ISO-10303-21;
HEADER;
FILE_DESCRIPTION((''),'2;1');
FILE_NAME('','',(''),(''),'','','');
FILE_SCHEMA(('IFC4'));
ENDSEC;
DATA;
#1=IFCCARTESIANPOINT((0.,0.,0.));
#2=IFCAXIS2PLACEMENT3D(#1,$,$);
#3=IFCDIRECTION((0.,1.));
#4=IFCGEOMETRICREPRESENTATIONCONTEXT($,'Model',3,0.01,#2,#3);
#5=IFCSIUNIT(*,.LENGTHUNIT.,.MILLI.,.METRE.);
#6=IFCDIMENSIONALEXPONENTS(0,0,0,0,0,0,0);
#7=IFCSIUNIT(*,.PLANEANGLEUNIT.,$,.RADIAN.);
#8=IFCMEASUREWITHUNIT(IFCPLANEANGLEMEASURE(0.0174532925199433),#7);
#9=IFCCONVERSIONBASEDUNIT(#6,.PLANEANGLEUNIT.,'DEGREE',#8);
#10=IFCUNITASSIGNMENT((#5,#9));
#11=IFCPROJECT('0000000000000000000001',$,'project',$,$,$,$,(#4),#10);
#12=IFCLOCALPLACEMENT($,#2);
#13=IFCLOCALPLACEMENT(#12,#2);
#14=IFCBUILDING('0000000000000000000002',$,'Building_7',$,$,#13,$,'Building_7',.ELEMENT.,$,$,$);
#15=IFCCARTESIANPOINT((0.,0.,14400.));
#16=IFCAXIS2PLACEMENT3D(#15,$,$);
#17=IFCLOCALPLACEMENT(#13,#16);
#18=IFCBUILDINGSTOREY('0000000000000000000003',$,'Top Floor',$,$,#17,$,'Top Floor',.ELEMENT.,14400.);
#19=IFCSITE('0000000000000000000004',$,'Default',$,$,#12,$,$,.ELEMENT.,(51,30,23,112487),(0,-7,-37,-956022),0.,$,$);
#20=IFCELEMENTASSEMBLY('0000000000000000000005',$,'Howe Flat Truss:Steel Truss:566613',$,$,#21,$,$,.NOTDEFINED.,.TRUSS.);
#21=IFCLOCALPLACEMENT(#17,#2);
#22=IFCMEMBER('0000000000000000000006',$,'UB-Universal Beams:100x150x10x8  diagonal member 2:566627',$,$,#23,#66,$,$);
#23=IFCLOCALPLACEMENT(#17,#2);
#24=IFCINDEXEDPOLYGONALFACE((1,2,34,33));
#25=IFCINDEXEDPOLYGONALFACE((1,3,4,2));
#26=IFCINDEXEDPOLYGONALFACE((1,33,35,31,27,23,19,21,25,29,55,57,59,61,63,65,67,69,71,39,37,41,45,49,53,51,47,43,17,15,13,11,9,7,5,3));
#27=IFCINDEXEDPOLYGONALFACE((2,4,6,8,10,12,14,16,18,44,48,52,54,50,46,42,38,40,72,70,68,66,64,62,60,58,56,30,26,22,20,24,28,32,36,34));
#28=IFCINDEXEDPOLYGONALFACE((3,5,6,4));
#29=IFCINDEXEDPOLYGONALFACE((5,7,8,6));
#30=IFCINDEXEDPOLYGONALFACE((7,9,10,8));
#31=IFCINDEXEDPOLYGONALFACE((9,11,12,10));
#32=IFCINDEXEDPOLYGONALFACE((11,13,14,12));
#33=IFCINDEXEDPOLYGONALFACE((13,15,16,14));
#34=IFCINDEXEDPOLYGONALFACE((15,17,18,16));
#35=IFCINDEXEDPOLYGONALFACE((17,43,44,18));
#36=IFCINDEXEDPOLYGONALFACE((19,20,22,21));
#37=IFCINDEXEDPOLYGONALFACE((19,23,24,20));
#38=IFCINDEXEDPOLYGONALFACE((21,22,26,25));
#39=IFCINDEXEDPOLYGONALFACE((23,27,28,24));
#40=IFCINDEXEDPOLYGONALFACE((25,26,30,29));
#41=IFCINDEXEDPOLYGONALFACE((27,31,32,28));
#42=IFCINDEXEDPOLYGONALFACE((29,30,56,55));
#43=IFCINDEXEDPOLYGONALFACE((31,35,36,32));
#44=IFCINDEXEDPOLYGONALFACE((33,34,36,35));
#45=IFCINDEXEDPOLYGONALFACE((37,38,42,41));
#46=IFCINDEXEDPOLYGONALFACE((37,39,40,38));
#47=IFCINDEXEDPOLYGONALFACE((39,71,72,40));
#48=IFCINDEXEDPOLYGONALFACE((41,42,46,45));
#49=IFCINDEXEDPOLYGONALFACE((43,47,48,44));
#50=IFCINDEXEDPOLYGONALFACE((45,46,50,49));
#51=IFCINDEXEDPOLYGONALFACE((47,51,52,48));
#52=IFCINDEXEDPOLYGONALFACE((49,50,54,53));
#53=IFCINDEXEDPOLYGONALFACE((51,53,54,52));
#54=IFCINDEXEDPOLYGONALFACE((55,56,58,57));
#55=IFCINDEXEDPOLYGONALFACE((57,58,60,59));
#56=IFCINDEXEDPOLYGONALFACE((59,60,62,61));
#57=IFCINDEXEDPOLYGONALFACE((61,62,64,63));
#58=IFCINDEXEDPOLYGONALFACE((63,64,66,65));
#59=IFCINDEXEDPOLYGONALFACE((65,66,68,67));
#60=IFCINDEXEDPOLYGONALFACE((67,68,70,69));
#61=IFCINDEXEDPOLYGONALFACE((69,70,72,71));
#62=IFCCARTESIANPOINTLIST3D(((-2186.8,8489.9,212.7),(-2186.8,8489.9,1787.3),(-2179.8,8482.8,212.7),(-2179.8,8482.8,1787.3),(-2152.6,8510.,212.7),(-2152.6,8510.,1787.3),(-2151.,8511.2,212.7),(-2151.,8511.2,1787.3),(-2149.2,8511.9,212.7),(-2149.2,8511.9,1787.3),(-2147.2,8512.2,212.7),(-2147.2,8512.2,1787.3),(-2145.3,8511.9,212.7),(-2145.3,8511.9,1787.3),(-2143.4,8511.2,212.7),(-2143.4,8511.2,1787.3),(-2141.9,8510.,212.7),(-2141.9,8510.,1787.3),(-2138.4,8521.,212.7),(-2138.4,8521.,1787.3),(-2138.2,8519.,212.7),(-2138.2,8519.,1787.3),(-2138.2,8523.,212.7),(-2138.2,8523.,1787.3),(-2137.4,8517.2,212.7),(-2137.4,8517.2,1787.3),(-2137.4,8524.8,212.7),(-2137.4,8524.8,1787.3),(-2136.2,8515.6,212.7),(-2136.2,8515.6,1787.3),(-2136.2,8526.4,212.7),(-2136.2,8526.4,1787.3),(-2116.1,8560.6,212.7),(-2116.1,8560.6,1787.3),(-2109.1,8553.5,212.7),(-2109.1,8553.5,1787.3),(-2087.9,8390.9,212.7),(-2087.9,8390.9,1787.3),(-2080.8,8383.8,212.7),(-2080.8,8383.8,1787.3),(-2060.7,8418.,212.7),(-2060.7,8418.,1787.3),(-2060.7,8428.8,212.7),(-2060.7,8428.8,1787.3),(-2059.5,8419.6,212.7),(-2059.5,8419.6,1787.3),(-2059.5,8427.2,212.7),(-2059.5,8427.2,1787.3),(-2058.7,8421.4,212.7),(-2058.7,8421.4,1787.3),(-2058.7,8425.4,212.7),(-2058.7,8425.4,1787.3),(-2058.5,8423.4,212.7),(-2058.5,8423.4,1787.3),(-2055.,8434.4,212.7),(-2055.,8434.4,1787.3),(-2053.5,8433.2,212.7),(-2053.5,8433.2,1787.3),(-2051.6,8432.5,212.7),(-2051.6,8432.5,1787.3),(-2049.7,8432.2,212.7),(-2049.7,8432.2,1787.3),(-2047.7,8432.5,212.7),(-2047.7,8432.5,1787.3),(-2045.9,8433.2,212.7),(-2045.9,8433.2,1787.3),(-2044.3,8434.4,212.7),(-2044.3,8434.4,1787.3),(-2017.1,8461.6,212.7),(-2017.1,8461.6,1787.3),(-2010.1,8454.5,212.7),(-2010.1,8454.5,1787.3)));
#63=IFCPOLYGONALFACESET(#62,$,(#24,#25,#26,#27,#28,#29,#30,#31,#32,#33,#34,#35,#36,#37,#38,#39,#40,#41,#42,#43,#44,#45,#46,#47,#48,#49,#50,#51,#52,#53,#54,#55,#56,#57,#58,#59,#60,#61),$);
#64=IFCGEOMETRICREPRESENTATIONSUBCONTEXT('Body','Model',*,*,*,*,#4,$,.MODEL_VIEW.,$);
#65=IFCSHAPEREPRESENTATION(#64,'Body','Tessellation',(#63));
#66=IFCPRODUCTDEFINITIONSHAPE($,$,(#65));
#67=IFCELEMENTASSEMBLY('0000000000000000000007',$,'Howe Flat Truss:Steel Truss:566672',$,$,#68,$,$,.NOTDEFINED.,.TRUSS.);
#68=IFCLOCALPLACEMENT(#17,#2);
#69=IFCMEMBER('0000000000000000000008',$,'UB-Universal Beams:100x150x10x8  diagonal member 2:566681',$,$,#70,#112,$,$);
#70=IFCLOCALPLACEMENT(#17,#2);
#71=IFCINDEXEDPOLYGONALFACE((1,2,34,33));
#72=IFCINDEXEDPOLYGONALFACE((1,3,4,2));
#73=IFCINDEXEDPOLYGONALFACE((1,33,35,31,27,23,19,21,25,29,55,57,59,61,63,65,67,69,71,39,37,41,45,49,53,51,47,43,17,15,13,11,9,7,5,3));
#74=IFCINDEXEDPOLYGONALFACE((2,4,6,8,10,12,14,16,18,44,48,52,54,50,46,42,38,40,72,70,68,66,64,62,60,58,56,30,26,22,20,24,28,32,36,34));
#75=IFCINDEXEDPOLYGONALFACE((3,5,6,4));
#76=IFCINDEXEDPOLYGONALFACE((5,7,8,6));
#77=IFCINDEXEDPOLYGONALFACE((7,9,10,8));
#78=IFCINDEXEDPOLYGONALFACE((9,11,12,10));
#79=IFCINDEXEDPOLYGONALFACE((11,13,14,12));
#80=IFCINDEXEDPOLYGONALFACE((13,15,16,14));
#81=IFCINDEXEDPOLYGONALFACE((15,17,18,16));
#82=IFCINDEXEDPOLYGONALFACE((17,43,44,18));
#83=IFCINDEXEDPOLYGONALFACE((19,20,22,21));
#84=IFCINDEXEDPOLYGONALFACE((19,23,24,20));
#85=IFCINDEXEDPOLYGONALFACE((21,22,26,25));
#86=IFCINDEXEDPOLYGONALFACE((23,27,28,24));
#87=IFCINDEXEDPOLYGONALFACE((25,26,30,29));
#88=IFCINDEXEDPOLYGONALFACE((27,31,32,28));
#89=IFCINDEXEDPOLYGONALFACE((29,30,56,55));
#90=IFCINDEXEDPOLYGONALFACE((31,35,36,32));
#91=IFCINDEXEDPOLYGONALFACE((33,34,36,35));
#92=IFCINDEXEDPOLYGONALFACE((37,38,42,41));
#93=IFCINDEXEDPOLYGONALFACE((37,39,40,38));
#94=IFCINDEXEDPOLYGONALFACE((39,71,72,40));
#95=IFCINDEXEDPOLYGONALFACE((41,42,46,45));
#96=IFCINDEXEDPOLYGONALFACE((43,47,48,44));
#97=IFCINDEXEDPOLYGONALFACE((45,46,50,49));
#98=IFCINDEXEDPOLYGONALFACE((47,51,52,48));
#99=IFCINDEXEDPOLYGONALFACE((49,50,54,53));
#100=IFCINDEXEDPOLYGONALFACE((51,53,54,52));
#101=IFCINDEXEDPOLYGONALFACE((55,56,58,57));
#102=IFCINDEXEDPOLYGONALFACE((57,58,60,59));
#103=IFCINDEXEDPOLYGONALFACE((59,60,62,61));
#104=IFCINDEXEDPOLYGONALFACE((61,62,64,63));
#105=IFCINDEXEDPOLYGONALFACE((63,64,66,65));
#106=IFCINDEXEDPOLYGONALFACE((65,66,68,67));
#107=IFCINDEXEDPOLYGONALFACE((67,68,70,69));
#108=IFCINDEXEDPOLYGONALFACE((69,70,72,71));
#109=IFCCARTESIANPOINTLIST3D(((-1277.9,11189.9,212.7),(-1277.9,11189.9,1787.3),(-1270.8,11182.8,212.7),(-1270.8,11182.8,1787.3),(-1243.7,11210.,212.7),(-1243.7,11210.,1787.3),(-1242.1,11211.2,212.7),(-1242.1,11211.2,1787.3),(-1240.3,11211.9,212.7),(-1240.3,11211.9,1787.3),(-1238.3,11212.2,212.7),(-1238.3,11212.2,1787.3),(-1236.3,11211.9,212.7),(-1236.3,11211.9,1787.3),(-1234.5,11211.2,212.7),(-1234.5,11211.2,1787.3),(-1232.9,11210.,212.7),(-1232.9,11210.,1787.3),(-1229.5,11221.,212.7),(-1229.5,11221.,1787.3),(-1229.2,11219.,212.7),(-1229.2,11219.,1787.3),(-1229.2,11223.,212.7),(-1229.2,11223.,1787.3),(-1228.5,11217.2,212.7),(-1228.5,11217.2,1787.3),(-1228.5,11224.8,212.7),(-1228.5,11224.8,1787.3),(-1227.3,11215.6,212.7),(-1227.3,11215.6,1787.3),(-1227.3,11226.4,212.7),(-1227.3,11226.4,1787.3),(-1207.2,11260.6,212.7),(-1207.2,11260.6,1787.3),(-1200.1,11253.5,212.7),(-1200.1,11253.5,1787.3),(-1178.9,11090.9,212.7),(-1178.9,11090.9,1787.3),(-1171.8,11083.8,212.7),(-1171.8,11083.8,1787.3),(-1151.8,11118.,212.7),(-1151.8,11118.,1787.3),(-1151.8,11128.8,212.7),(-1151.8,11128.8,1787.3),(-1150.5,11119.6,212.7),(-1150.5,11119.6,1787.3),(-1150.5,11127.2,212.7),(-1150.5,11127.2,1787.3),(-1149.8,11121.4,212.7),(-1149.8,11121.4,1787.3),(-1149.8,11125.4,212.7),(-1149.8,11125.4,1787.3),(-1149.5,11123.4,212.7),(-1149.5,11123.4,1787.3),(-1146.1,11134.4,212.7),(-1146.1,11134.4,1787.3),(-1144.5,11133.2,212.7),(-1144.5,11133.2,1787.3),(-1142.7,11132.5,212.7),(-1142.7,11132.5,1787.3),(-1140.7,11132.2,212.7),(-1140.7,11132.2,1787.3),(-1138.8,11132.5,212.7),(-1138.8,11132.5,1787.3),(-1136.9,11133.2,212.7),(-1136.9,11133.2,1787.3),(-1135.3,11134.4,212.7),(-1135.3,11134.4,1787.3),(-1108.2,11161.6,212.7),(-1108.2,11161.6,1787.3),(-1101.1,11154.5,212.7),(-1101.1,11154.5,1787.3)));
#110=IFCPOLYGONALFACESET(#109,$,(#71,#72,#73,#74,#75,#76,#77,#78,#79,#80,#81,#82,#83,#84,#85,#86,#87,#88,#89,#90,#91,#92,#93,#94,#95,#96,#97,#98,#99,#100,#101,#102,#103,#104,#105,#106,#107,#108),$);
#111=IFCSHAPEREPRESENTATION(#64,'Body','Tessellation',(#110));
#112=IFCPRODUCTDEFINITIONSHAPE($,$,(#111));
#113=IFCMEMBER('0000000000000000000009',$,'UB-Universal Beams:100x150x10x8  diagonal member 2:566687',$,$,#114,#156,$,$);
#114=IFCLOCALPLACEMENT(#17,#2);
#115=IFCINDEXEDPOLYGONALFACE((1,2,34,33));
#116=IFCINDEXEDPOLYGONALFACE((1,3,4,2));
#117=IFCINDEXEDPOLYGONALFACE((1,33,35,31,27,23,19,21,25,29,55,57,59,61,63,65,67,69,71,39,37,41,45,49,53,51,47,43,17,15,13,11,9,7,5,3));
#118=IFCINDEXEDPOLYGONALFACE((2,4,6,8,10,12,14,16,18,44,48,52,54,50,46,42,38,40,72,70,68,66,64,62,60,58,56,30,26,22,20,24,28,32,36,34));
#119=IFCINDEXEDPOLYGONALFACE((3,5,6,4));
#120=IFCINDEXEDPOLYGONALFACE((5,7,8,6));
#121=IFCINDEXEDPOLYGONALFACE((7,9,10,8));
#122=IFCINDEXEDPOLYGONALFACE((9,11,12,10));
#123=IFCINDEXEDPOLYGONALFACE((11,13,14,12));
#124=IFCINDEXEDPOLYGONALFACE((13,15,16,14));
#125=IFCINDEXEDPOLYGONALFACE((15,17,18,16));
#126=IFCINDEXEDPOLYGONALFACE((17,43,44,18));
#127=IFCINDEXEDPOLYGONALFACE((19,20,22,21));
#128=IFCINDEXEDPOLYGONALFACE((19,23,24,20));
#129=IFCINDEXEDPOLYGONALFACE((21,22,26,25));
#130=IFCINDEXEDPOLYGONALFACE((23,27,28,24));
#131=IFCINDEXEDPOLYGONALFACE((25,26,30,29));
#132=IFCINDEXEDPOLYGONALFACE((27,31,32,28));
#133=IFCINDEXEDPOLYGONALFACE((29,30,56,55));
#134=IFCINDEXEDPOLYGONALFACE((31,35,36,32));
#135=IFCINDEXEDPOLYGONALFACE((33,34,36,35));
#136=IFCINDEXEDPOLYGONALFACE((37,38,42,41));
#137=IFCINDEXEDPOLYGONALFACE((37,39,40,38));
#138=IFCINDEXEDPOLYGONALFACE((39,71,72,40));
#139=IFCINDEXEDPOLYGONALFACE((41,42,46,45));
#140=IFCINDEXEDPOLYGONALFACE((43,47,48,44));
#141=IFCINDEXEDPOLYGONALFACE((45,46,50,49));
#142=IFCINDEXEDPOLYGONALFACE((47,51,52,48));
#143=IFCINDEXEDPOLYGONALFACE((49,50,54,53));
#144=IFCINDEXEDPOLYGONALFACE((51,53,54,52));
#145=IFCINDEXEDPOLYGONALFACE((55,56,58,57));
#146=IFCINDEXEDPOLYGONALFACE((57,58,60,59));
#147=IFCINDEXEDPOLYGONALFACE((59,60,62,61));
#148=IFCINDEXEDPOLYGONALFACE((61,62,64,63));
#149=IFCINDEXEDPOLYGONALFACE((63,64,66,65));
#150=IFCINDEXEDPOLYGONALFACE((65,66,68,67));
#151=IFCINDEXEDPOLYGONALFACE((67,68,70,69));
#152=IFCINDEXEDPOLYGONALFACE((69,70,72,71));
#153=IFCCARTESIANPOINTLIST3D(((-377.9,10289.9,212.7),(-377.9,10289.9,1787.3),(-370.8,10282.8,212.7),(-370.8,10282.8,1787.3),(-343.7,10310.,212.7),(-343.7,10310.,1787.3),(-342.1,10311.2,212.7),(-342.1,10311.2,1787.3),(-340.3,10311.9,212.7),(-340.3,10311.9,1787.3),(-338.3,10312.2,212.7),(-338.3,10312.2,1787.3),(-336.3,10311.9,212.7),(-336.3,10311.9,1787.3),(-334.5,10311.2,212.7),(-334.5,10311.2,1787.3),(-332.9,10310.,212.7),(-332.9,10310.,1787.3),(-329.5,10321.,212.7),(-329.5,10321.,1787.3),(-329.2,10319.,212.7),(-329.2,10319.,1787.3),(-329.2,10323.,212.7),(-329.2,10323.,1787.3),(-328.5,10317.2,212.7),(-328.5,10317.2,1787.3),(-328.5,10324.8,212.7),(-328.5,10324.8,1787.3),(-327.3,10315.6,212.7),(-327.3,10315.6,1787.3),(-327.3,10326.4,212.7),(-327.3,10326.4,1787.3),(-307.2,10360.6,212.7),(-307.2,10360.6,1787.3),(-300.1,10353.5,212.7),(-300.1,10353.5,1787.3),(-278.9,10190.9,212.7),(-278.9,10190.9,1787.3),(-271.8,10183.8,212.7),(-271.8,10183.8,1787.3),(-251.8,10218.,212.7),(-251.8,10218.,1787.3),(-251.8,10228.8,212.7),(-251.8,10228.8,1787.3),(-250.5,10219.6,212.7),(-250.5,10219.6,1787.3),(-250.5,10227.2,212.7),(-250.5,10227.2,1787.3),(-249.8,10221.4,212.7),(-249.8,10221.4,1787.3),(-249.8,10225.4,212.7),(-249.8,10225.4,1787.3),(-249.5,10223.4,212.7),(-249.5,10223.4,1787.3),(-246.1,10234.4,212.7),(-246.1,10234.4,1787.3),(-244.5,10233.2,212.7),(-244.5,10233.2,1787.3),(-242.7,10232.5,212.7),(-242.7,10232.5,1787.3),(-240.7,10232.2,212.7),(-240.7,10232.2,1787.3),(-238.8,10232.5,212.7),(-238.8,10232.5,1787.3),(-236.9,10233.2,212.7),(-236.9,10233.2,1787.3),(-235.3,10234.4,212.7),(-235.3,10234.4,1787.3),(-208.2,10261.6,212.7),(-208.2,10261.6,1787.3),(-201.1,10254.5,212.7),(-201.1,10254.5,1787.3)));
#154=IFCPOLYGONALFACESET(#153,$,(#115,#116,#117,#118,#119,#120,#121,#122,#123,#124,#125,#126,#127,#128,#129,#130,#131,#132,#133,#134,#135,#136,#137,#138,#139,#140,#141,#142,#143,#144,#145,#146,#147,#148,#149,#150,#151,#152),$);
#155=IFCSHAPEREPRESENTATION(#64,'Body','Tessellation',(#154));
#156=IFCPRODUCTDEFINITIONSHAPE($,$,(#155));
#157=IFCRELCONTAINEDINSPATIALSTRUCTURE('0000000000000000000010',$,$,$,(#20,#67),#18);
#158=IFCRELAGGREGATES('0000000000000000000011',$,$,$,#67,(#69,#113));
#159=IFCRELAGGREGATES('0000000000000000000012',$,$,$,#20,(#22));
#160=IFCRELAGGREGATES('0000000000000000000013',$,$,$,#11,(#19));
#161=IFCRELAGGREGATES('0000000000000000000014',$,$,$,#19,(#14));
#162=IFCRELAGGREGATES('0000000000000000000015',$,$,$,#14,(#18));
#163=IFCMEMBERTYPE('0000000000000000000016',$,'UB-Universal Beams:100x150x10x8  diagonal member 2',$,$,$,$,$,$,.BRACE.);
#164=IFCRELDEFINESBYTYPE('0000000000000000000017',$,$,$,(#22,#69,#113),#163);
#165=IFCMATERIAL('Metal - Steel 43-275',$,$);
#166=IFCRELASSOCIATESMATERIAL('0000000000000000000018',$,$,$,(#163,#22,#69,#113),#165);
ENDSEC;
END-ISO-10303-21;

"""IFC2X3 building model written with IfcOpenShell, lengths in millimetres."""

from ifc_helpers import new_model, entity, si_unit, converted_unit, direction, frame, frame_2d, origin, place, context, subcontext, project, spatial, polyline, circle_curve, parameter, trimmed, segment, composite_curve, outline, extrude, source, transform, mapped, material, type_object, type_shapes, element, aggregate, save


model = new_model("IFC2X3")

# Units and contexts
model_context = context("Model", 3, precision=0.01, world=origin(), true_north=direction((0.0, 1.0)))
body_context = subcontext(model_context, "Body", "Model", "MODEL_VIEW")
ifc_project = project(units=[si_unit("LENGTHUNIT", "METRE", prefix="MILLI"), converted_unit("PLANEANGLEUNIT", "DEGREE", entity("IfcPlaneAngleMeasure", 0.0174532925199433), si_unit("PLANEANGLEUNIT", "RADIAN"), dimensions=[0, 0, 0, 0, 0, 0, 0])], contexts=[model_context])

# Site, building, storey
site_placement = place(None, origin())
site = spatial("IfcSite", under=ifc_project, at=site_placement, Name="Default", CompositionType="ELEMENT", RefLatitude=(51, 30, 23, 112487), RefLongitude=(0, -7, -37, -956022), RefElevation=0.0)
building_placement = place(site_placement, origin())
building = spatial("IfcBuilding", under=site, at=building_placement, Name="Building_7", LongName="Building_7", CompositionType="ELEMENT")
storey_placement = place(building_placement, frame((0.0, 0.0, 14400.0)))
storey = spatial("IfcBuildingStorey", under=building, at=storey_placement, Name="Top Floor", LongName="Top Floor", CompositionType="ELEMENT", Elevation=14400.0)

# Shared definitions
ifc_material = material(Name="Metal - Steel 43-275")

# Shared definitions
member_type_1 = type_object("IfcMemberType", Name="UB-Universal Beams:100x150x10x8  diagonal member 2", PredefinedType="BRACE", material=ifc_material)
shared_shape_1 = source(origin(), body_context, "Body", "SweptSolid", [
    extrude(outline(composite_curve([segment(polyline([(-50.0, -65.0), (-50.0, -75.0)]), True, "CONTINUOUS"), segment(polyline([(-50.0, -75.0), (50.0, -75.0)]), True, "CONTINUOUS"), segment(polyline([(50.0, -75.0), (50.0, -65.0)]), True, "CONTINUOUS"), segment(polyline([(50.0, -65.0), (11.6, -65.0)]), True, "CONTINUOUS"), segment(trimmed(circle_curve(frame_2d((11.6, -57.4), x_axis=(1.0, 0.0)), 7.6), [parameter(180.0)], [parameter(270.0)], True, "PARAMETER"), False, "CONTINUOUS"), segment(polyline([(4.0, -57.4), (4.0, 57.4)]), True, "CONTINUOUS"), segment(trimmed(circle_curve(frame_2d((11.6, 57.4), x_axis=(1.0, 0.0)), 7.6), [parameter(90.0)], [parameter(180.0)], True, "PARAMETER"), False, "CONTINUOUS"), segment(polyline([(11.6, 65.0), (50.0, 65.0)]), True, "CONTINUOUS"), segment(polyline([(50.0, 65.0), (50.0, 75.0)]), True, "CONTINUOUS"), segment(polyline([(50.0, 75.0), (-50.0, 75.0)]), True, "CONTINUOUS"), segment(polyline([(-50.0, 75.0), (-50.0, 65.0)]), True, "CONTINUOUS"), segment(polyline([(-50.0, 65.0), (-11.6, 65.0)]), True, "CONTINUOUS"), segment(trimmed(circle_curve(frame_2d((-11.6, 57.4), x_axis=(1.0, 0.0)), 7.6), [parameter(360.0)], [parameter(90.0)], True, "PARAMETER"), False, "CONTINUOUS"), segment(polyline([(-4.0, 57.4), (-4.0, -57.4)]), True, "CONTINUOUS"), segment(trimmed(circle_curve(frame_2d((-11.6, -57.4), x_axis=(1.0, 0.0)), 7.6), [parameter(270.0)], [parameter(360.0)], True, "PARAMETER"), False, "CONTINUOUS"), segment(polyline([(-11.6, -65.0), (-50.0, -65.0)]), True, "CONTINUOUS")], self_intersect=False)), frame((-787.3, 0.0, 0.0), z_axis=(-1.0, 0.0, 0.0), x_axis=(0.0, -1.0, 0.0)), (0.0, 0.0, -1.0), 1574.6),
])
type_shapes(member_type_1, [shared_shape_1])

# Element assemblies, members
assembly_1_placement = place(storey_placement, origin())
assembly_1 = element("IfcElementAssembly", 1, at=assembly_1_placement, inside=storey, Name="Howe Flat Truss:Steel Truss:566613", AssemblyPlace="NOTDEFINED", PredefinedType="TRUSS")
member_1_placement = place(assembly_1_placement, frame((-2098.5, 8472.2, 1000.0), z_axis=(0.707107, -0.707107, 0.0), x_axis=(0.0, 0.0, 1.0)))
member_1 = element("IfcMember", 2, at=member_1_placement, type_object=member_type_1, material=ifc_material, Name="UB-Universal Beams:100x150x10x8  diagonal member 2:566627", context=body_context, shape_type="MappedRepresentation", body=[
    mapped(shared_shape_1, transform((0.0, 0.0, 0.0), scale=1.0)),
])
assembly_2_placement = place(storey_placement, origin())
assembly_2 = element("IfcElementAssembly", 3, at=assembly_2_placement, inside=storey, Name="Howe Flat Truss:Steel Truss:566672", AssemblyPlace="NOTDEFINED", PredefinedType="TRUSS")
member_2_placement = place(assembly_2_placement, frame((-1189.5, 11172.2, 1000.0), z_axis=(-0.707107, 0.707107, 0.0), x_axis=(0.0, 0.0, 1.0)))
member_2 = element("IfcMember", 4, at=member_2_placement, type_object=member_type_1, material=ifc_material, Name="UB-Universal Beams:100x150x10x8  diagonal member 2:566681", context=body_context, shape_type="MappedRepresentation", body=[
    mapped(shared_shape_1, transform((0.0, 0.0, 0.0), scale=1.0)),
])
member_3_placement = place(assembly_2_placement, frame((-289.5, 10272.2, 1000.0), z_axis=(-0.707107, 0.707107, 0.0), x_axis=(0.0, 0.0, 1.0)))
member_3 = element("IfcMember", 5, at=member_3_placement, type_object=member_type_1, material=ifc_material, Name="UB-Universal Beams:100x150x10x8  diagonal member 2:566687", context=body_context, shape_type="MappedRepresentation", body=[
    mapped(shared_shape_1, transform((0.0, 0.0, 0.0), scale=1.0)),
])

aggregate(assembly_2, [member_2, member_3])
aggregate(assembly_1, [member_1])

save(model, "model.ifc")
